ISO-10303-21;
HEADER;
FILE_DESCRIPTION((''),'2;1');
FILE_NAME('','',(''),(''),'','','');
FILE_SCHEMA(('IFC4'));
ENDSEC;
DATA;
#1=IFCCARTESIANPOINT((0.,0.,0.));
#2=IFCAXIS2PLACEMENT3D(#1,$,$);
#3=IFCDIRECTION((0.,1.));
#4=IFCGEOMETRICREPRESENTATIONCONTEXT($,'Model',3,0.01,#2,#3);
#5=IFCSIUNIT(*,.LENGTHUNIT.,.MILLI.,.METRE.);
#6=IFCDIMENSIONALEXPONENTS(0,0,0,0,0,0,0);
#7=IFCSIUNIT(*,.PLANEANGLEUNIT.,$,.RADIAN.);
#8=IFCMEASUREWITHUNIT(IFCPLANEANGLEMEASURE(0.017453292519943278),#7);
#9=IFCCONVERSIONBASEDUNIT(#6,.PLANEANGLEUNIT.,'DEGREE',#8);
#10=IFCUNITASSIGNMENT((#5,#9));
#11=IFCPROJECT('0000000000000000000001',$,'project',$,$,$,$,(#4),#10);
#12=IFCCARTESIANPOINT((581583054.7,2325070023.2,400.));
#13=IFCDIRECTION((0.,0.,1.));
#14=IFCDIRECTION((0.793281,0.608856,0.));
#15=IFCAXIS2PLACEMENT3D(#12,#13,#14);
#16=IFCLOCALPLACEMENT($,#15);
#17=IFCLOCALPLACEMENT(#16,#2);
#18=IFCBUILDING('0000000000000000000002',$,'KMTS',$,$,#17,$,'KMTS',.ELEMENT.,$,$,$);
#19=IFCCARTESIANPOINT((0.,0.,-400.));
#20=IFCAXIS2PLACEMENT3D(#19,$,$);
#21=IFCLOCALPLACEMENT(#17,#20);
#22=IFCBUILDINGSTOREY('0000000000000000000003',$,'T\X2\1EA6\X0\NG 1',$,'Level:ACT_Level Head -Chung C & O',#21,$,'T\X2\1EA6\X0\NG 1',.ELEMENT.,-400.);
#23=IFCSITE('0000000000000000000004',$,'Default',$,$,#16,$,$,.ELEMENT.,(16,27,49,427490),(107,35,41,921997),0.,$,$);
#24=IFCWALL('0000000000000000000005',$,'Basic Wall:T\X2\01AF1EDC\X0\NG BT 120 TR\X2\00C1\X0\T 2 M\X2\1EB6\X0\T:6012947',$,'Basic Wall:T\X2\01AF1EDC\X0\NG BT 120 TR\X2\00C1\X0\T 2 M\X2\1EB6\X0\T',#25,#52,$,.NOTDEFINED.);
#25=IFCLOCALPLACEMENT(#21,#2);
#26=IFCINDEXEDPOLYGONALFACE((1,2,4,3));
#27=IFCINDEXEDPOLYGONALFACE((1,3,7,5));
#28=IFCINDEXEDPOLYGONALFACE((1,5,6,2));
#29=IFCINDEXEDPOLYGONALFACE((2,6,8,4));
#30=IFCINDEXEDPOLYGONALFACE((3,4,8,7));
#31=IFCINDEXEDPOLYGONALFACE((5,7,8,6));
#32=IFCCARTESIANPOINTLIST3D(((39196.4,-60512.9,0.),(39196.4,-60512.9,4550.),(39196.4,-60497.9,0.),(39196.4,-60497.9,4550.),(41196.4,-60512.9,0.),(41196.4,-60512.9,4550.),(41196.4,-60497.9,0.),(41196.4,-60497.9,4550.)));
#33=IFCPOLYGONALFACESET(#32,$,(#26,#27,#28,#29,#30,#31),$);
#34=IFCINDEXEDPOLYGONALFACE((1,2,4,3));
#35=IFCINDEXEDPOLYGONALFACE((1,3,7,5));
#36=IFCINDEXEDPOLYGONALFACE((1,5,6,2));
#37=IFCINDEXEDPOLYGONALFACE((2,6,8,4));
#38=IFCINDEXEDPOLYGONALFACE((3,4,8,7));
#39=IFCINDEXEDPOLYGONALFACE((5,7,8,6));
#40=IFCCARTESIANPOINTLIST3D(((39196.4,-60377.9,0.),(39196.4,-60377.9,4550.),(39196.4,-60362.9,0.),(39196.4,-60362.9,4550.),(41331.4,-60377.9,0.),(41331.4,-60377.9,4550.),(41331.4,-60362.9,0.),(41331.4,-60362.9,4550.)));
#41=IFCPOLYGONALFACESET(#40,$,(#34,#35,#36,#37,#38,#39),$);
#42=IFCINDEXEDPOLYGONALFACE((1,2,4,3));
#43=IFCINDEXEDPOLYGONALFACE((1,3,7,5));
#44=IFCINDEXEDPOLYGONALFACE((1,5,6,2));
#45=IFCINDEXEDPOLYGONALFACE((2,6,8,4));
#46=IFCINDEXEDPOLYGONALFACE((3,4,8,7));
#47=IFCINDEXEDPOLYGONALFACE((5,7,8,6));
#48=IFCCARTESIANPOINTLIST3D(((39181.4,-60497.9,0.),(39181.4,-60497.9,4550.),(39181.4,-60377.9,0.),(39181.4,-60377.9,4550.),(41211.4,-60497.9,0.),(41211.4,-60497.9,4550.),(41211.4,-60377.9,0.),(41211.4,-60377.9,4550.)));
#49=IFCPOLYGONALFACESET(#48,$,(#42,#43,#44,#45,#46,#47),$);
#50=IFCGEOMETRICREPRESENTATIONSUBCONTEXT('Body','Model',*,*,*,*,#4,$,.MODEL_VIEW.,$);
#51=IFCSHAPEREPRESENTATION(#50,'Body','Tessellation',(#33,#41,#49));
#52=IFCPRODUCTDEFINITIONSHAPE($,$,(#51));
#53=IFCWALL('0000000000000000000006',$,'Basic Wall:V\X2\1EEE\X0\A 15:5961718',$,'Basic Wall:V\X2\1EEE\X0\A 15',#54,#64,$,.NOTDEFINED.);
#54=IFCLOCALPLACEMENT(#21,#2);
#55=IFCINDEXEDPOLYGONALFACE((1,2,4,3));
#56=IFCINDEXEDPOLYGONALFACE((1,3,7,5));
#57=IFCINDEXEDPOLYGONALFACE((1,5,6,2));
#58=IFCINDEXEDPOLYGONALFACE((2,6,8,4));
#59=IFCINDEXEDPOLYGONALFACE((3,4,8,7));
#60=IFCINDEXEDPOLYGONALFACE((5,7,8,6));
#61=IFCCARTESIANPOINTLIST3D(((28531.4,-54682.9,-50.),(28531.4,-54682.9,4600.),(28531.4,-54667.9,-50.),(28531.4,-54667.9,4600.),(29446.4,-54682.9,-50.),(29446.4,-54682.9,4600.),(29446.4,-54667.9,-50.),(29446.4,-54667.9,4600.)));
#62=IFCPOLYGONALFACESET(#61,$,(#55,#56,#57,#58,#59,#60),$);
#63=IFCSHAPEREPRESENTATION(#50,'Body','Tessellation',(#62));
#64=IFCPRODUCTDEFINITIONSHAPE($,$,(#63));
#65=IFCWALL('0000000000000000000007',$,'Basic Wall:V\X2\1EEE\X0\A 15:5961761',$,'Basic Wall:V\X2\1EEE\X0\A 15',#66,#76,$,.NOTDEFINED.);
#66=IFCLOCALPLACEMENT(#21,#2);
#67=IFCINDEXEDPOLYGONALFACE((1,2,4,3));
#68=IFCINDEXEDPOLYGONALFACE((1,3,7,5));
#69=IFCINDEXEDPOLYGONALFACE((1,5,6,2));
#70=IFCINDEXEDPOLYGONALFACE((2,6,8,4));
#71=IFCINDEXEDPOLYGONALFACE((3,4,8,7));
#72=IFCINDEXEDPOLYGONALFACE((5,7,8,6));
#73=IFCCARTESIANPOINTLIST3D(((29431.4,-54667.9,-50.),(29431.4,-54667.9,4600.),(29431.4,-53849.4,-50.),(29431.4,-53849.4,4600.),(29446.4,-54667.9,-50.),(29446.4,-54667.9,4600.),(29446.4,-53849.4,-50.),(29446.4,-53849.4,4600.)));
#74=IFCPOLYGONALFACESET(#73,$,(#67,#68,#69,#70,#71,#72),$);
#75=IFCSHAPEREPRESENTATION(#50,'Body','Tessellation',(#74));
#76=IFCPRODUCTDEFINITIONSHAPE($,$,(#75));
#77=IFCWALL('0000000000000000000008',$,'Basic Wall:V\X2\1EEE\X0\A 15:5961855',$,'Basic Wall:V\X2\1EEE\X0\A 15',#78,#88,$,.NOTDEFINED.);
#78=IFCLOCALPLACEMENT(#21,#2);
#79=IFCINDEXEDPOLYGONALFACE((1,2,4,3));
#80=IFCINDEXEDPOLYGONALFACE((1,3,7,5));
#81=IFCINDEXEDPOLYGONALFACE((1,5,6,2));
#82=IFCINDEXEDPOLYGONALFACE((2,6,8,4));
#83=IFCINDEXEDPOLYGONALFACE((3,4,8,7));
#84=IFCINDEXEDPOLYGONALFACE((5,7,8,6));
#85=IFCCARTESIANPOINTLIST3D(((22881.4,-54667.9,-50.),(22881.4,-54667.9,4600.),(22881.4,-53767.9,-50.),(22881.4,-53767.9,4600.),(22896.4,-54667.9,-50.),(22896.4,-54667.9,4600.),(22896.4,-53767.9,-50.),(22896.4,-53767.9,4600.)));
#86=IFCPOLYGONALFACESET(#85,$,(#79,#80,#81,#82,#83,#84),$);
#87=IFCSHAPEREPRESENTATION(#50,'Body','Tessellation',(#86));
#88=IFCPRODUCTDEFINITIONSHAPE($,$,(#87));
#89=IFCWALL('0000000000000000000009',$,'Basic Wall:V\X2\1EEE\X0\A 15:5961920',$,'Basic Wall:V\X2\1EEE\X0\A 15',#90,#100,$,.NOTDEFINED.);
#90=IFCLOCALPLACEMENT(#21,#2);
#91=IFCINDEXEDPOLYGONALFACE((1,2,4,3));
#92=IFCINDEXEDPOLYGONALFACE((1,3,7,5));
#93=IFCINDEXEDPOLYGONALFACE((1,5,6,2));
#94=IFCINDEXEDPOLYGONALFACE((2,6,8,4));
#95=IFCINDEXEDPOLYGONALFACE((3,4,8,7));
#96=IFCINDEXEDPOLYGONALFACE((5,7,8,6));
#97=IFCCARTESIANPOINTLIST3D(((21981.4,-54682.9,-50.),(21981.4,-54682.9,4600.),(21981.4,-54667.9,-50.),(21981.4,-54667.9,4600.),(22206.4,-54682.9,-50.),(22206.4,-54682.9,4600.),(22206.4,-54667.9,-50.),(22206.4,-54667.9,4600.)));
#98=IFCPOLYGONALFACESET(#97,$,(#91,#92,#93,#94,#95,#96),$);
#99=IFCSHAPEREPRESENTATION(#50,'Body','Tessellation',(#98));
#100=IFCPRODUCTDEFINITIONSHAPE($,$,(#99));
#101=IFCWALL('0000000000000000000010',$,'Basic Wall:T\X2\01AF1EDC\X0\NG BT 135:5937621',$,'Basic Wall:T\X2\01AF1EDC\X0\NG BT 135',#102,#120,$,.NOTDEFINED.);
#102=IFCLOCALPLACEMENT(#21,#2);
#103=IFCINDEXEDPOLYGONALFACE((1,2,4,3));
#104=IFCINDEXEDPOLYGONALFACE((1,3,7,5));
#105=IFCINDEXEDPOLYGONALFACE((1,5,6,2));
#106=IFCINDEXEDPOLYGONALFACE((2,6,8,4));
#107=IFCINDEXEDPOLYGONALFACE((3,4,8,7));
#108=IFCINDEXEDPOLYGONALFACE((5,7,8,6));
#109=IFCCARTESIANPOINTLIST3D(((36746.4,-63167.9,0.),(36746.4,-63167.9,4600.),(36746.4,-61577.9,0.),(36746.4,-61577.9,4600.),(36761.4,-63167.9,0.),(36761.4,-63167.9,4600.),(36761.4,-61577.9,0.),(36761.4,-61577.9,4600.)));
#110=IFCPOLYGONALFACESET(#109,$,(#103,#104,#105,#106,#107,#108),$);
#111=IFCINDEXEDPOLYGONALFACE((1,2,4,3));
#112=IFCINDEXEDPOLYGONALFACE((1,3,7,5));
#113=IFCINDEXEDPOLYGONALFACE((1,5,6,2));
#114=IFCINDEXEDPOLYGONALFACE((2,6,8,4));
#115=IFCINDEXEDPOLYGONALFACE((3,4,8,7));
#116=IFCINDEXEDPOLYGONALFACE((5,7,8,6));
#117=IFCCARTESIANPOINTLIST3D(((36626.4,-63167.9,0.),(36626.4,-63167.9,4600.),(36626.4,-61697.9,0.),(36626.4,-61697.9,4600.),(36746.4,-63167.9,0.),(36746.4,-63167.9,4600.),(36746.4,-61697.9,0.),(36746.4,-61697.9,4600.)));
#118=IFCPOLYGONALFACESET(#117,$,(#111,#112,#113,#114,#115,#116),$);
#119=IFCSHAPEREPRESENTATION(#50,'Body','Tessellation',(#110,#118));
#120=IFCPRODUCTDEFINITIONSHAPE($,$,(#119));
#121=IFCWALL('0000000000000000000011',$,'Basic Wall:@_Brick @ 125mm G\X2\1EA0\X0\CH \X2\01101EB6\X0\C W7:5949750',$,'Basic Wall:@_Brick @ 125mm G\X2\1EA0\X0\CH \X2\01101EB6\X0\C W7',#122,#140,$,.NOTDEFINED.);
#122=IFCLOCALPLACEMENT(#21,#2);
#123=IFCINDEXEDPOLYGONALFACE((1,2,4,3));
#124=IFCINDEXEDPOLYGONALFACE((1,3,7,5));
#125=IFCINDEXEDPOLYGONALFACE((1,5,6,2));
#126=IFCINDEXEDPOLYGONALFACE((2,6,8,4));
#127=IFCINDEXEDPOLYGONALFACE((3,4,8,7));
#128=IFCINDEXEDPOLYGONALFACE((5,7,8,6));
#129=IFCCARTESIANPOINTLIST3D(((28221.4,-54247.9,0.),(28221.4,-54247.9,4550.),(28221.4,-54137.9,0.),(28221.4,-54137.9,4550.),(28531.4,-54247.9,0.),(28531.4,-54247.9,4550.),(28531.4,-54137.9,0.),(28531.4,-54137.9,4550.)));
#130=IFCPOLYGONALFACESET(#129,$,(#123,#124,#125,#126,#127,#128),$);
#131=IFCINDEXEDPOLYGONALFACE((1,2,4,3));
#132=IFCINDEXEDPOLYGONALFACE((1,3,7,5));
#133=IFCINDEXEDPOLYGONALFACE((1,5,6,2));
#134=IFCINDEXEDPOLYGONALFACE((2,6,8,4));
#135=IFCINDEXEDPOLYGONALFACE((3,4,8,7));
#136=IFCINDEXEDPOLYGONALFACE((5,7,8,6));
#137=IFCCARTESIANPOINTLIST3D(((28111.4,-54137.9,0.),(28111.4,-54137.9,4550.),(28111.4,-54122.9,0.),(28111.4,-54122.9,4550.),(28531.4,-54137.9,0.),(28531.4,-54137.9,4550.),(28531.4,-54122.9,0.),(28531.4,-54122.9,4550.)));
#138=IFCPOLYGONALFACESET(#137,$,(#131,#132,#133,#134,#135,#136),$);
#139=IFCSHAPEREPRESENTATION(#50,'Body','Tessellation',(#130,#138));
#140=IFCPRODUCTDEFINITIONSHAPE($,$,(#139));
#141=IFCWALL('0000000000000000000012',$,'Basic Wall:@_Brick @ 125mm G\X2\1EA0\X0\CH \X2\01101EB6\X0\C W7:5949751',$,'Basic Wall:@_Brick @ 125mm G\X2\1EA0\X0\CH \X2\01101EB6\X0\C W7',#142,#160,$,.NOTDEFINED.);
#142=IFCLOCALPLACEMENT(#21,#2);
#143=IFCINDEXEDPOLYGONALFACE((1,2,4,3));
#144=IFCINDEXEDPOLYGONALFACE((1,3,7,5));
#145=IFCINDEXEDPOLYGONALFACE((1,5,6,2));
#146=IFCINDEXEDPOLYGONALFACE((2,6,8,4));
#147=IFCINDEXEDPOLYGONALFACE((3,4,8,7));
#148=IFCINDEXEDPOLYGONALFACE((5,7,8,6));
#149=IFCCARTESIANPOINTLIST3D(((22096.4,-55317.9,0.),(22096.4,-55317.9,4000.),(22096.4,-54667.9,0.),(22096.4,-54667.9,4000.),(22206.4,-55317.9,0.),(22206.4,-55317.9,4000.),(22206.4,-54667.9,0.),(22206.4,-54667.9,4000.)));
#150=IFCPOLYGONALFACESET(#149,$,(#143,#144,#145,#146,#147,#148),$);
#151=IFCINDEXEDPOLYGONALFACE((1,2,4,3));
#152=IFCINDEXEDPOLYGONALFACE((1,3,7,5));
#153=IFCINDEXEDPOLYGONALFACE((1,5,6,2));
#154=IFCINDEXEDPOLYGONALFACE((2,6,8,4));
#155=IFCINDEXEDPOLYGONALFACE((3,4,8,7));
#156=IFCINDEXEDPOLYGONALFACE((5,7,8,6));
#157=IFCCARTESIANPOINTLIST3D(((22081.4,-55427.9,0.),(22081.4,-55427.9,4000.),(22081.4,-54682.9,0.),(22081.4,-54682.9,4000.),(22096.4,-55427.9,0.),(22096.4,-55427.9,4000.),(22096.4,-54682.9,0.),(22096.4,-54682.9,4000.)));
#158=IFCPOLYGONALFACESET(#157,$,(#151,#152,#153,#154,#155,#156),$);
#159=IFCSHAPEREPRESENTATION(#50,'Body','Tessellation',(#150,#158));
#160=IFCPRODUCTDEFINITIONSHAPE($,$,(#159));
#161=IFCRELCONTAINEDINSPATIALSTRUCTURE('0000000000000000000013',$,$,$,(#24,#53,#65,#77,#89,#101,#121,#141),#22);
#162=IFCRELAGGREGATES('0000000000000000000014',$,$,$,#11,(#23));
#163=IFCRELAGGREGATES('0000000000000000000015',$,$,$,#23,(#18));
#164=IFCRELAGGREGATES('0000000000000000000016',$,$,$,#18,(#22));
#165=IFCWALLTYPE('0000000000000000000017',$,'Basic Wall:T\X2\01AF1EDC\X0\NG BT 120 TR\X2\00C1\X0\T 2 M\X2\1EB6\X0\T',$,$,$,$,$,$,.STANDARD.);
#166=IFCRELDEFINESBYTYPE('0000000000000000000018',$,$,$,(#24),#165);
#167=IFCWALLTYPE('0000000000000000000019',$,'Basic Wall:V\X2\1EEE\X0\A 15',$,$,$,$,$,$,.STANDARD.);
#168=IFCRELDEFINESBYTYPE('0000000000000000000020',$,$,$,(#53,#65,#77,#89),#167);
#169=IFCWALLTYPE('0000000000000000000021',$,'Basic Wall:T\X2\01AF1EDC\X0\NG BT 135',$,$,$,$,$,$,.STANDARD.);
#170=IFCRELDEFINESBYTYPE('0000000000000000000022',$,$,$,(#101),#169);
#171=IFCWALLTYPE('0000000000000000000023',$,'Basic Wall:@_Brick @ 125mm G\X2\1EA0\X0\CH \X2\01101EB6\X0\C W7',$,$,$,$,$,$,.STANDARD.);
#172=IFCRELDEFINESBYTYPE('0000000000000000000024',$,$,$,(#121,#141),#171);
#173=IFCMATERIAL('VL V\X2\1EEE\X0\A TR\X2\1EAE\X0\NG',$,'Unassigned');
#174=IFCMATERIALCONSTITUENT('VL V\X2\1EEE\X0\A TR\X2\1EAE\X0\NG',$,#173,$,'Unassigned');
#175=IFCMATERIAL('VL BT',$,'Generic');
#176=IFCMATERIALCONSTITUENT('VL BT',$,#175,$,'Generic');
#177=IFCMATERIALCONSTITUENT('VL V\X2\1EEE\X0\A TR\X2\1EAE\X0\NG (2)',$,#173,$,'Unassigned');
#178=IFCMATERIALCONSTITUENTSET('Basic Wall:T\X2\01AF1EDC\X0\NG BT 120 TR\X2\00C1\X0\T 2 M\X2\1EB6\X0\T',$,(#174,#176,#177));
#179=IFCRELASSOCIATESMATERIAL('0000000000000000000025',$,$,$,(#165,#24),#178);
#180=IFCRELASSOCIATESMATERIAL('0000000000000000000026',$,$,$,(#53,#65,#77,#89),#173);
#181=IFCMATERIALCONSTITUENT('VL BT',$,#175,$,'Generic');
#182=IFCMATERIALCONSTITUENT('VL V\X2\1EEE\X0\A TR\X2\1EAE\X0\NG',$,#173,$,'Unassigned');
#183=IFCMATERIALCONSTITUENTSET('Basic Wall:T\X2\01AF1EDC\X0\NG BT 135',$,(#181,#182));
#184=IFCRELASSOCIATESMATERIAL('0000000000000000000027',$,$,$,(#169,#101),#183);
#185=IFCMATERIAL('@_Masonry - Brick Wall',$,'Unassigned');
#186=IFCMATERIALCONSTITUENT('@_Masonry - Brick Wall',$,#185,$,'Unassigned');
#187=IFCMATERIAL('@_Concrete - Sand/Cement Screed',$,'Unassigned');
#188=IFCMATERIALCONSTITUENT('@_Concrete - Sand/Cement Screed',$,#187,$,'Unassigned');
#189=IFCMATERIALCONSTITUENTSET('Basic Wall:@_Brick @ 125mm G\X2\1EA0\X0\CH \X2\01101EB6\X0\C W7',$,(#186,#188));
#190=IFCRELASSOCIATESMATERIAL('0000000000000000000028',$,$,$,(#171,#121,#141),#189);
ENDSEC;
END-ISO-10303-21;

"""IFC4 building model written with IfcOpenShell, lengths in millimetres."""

from ifc_helpers import new_model, entity, si_unit, converted_unit, direction, frame, origin, place, context, subcontext, project, spatial, indexed_curve, outline, extrude, material, constituent, constituent_set, type_object, element, save


model = new_model("IFC4")

# Units and contexts
model_context = context("Model", 3, precision=0.01, world=origin(), true_north=direction((0.0, 1.0)))
body_context = subcontext(model_context, "Body", "Model", "MODEL_VIEW")
ifc_project = project(units=[si_unit("LENGTHUNIT", "METRE", prefix="MILLI"), converted_unit("PLANEANGLEUNIT", "DEGREE", entity("IfcPlaneAngleMeasure", 0.017453292519943278), si_unit("PLANEANGLEUNIT", "RADIAN"), dimensions=[0, 0, 0, 0, 0, 0, 0])], contexts=[model_context])

# Site, building, storey
site_placement = place(None, frame((581583054.7, 2325070023.2, 400.0), z_axis=(0.0, 0.0, 1.0), x_axis=(0.793281, 0.608856, 0.0)))
site = spatial("IfcSite", under=ifc_project, at=site_placement, Name="Default", CompositionType="ELEMENT", RefLatitude=(16, 27, 49, 427490), RefLongitude=(107, 35, 41, 921997), RefElevation=0.0)
building_placement = place(site_placement, origin())
building = spatial("IfcBuilding", under=site, at=building_placement, Name="KMTS", LongName="KMTS", CompositionType="ELEMENT")
storey_placement = place(building_placement, frame((0.0, 0.0, -400.0)))
storey = spatial("IfcBuildingStorey", under=building, at=storey_placement, Name="TẦNG 1", ObjectType="Level:ACT_Level Head -Chung C & O", LongName="TẦNG 1", CompositionType="ELEMENT", Elevation=-400.0)

# Shared definitions
ifc_material_1 = material(Name="VL VỮA TRẮNG", Category="Unassigned")
ifc_material_2 = material(Name="VL BT", Category="Generic")

# Shared definitions
ifc_constituent_1 = constituent(ifc_material_1, Name="VL VỮA TRẮNG", Category="Unassigned")
ifc_constituent_2 = constituent(ifc_material_2, Name="VL BT", Category="Generic")
ifc_constituent_3 = constituent(ifc_material_1, Name="VL VỮA TRẮNG (2)", Category="Unassigned")
ifc_constituent_set_1 = constituent_set(constituents=[ifc_constituent_1, ifc_constituent_2, ifc_constituent_3], Name="Basic Wall:TƯỜNG BT 120 TRÁT 2 MẶT")
wall_type_1 = type_object("IfcWallType", Name="Basic Wall:TƯỜNG BT 120 TRÁT 2 MẶT", PredefinedType="STANDARD", material=ifc_constituent_set_1)

# Walls
wall_1_placement = place(storey_placement, frame((39196.4, -60437.9, 0.0)))
element("IfcWall", 1, at=wall_1_placement, inside=storey, type_object=wall_type_1, material=ifc_constituent_set_1, Name="Basic Wall:TƯỜNG BT 120 TRÁT 2 MẶT:6012947", ObjectType="Basic Wall:TƯỜNG BT 120 TRÁT 2 MẶT", PredefinedType="NOTDEFINED", context=body_context, shape_type="SweptSolid", body=[
    extrude(outline(indexed_curve([(-7.5, -1000.0), (7.5, -1000.0), (7.5, 1000.0), (-7.5, 1000.0), (-7.5, -1000.0)], self_intersect=False)), frame((1000.0, -67.5, 0.0), z_axis=(0.0, 0.0, 1.0), x_axis=(0.0, 1.0, 0.0)), (0.0, 0.0, 1.0), 4550.0),
    extrude(outline(indexed_curve([(-7.5, -1067.5), (7.5, -1067.5), (7.5, 1067.5), (-7.5, 1067.5), (-7.5, -1067.5)], self_intersect=False)), frame((1067.5, 67.5, 0.0), z_axis=(0.0, 0.0, 1.0), x_axis=(0.0, -1.0, 0.0)), (0.0, 0.0, 1.0), 4550.0),
    extrude(outline(indexed_curve([(-1015.0, -60.0), (1015.0, -60.0), (1015.0, 60.0), (-1015.0, 60.0), (-1015.0, -60.0)], self_intersect=False)), frame((1000.0, 0.0, 0.0)), (0.0, 0.0, 1.0), 4550.0),
])
wall_type_2 = type_object("IfcWallType", Name="Basic Wall:VỮA 15", PredefinedType="STANDARD")
wall_2_placement = place(storey_placement, frame((28531.4, -54675.4, -50.0)))
element("IfcWall", 2, at=wall_2_placement, inside=storey, type_object=wall_type_2, material=ifc_material_1, Name="Basic Wall:VỮA 15:5961718", ObjectType="Basic Wall:VỮA 15", PredefinedType="NOTDEFINED", context=body_context, shape_type="SweptSolid", body=[
    extrude(outline(indexed_curve([(915.0, 7.5), (0.0, 7.5), (0.0, -7.5), (915.0, -7.5), (915.0, 7.5)], self_intersect=False)), origin(), (0.0, 0.0, 1.0), 4650.0),
])
wall_3_placement = place(storey_placement, frame((29438.9, -54667.9, -50.0), z_axis=(0.0, 0.0, 1.0), x_axis=(0.0, 1.0, 0.0)))
element("IfcWall", 3, at=wall_3_placement, inside=storey, type_object=wall_type_2, material=ifc_material_1, Name="Basic Wall:VỮA 15:5961761", ObjectType="Basic Wall:VỮA 15", PredefinedType="NOTDEFINED", context=body_context, shape_type="SweptSolid", body=[
    extrude(outline(indexed_curve([(818.5, 7.5), (0.0, 7.5), (0.0, -7.5), (818.5, -7.5), (818.5, 7.5)], self_intersect=False)), origin(), (0.0, 0.0, 1.0), 4650.0),
])
wall_4_placement = place(storey_placement, frame((22888.9, -54667.9, -50.0), z_axis=(0.0, 0.0, 1.0), x_axis=(0.0, 1.0, 0.0)))
element("IfcWall", 4, at=wall_4_placement, inside=storey, type_object=wall_type_2, material=ifc_material_1, Name="Basic Wall:VỮA 15:5961855", ObjectType="Basic Wall:VỮA 15", PredefinedType="NOTDEFINED", context=body_context, shape_type="SweptSolid", body=[
    extrude(outline(indexed_curve([(900.0, 7.5), (0.0, 7.5), (0.0, -7.5), (900.0, -7.5), (900.0, 7.5)], self_intersect=False)), origin(), (0.0, 0.0, 1.0), 4650.0),
])
wall_5_placement = place(storey_placement, frame((21981.4, -54675.4, -50.0)))
element("IfcWall", 5, at=wall_5_placement, inside=storey, type_object=wall_type_2, material=ifc_material_1, Name="Basic Wall:VỮA 15:5961920", ObjectType="Basic Wall:VỮA 15", PredefinedType="NOTDEFINED", context=body_context, shape_type="SweptSolid", body=[
    extrude(outline(indexed_curve([(225.0, 7.5), (0.0, 7.5), (0.0, -7.5), (225.0, -7.5), (225.0, 7.5)], self_intersect=False)), origin(), (0.0, 0.0, 1.0), 4650.0),
])
ifc_constituent_4 = constituent(ifc_material_2, Name="VL BT", Category="Generic")
ifc_constituent_5 = constituent(ifc_material_1, Name="VL VỮA TRẮNG", Category="Unassigned")
ifc_constituent_set_2 = constituent_set(constituents=[ifc_constituent_4, ifc_constituent_5], Name="Basic Wall:TƯỜNG BT 135")
wall_type_3 = type_object("IfcWallType", Name="Basic Wall:TƯỜNG BT 135", PredefinedType="STANDARD", material=ifc_constituent_set_2)
wall_6_placement = place(storey_placement, frame((36693.9, -63167.9, 0.0), z_axis=(0.0, 0.0, 1.0), x_axis=(0.0, 1.0, 0.0)))
element("IfcWall", 6, at=wall_6_placement, inside=storey, type_object=wall_type_3, material=ifc_constituent_set_2, Name="Basic Wall:TƯỜNG BT 135:5937621", ObjectType="Basic Wall:TƯỜNG BT 135", PredefinedType="NOTDEFINED", context=body_context, shape_type="SweptSolid", body=[
    extrude(outline(indexed_curve([(-7.5, -795.0), (7.5, -795.0), (7.5, 795.0), (-7.5, 795.0), (-7.5, -795.0)], self_intersect=False)), frame((795.0, -60.0, 0.0), z_axis=(0.0, 0.0, 1.0), x_axis=(0.0, 1.0, 0.0)), (0.0, 0.0, 1.0), 4600.0),
    extrude(outline(indexed_curve([(-60.0, -735.0), (60.0, -735.0), (60.0, 735.0), (-60.0, 735.0), (-60.0, -735.0)], self_intersect=False)), frame((735.0, 7.5, 0.0), z_axis=(0.0, 0.0, 1.0), x_axis=(0.0, -1.0, 0.0)), (0.0, 0.0, 1.0), 4600.0),
])
ifc_material_3 = material(Name="@_Masonry - Brick Wall", Category="Unassigned")
ifc_constituent_6 = constituent(ifc_material_3, Name="@_Masonry - Brick Wall", Category="Unassigned")
ifc_material_4 = material(Name="@_Concrete - Sand/Cement Screed", Category="Unassigned")
ifc_constituent_7 = constituent(ifc_material_4, Name="@_Concrete - Sand/Cement Screed", Category="Unassigned")
ifc_constituent_set_3 = constituent_set(constituents=[ifc_constituent_6, ifc_constituent_7], Name="Basic Wall:@_Brick @ 125mm GẠCH ĐẶC W7")
wall_type_4 = type_object("IfcWallType", Name="Basic Wall:@_Brick @ 125mm GẠCH ĐẶC W7", PredefinedType="STANDARD", material=ifc_constituent_set_3)
wall_7_placement = place(storey_placement, frame((28531.4, -54185.4, 0.0), z_axis=(0.0, 0.0, 1.0), x_axis=(-1.0, 0.0, 0.0)))
element("IfcWall", 7, at=wall_7_placement, inside=storey, type_object=wall_type_4, material=ifc_constituent_set_3, Name="Basic Wall:@_Brick @ 125mm GẠCH ĐẶC W7:5949750", ObjectType="Basic Wall:@_Brick @ 125mm GẠCH ĐẶC W7", PredefinedType="NOTDEFINED", context=body_context, shape_type="SweptSolid", body=[
    extrude(outline(indexed_curve([(-55.0, -155.0), (55.0, -155.0), (55.0, 155.0), (-55.0, 155.0), (-55.0, -155.0)], self_intersect=False)), frame((155.0, 7.5, 0.0), z_axis=(0.0, 0.0, 1.0), x_axis=(0.0, -1.0, 0.0)), (0.0, 0.0, 1.0), 4550.0),
    extrude(outline(indexed_curve([(-7.5, -210.0), (7.5, -210.0), (7.5, 210.0), (-7.5, 210.0), (-7.5, -210.0)], self_intersect=False)), frame((210.0, -55.0, 0.0), z_axis=(0.0, 0.0, 1.0), x_axis=(0.0, 1.0, 0.0)), (0.0, 0.0, 1.0), 4550.0),
])
wall_8_placement = place(storey_placement, frame((22143.9, -54682.9, 0.0), z_axis=(0.0, 0.0, 1.0), x_axis=(0.0, -1.0, 0.0)))
element("IfcWall", 8, at=wall_8_placement, inside=storey, type_object=wall_type_4, material=ifc_constituent_set_3, Name="Basic Wall:@_Brick @ 125mm GẠCH ĐẶC W7:5949751", ObjectType="Basic Wall:@_Brick @ 125mm GẠCH ĐẶC W7", PredefinedType="NOTDEFINED", context=body_context, shape_type="SweptSolid", body=[
    extrude(outline(indexed_curve([(-55.0, -325.0), (55.0, -325.0), (55.0, 325.0), (-55.0, 325.0), (-55.0, -325.0)], self_intersect=False)), frame((310.0, 7.5, 0.0), z_axis=(0.0, 0.0, 1.0), x_axis=(0.0, -1.0, 0.0)), (0.0, 0.0, 1.0), 4000.0),
    extrude(outline(indexed_curve([(-7.5, -372.5), (7.5, -372.5), (7.5, 372.5), (-7.5, 372.5), (-7.5, -372.5)], self_intersect=False)), frame((372.5, -55.0, 0.0), z_axis=(0.0, 0.0, 1.0), x_axis=(0.0, 1.0, 0.0)), (0.0, 0.0, 1.0), 4000.0),
])

save(model, "model.ifc")
